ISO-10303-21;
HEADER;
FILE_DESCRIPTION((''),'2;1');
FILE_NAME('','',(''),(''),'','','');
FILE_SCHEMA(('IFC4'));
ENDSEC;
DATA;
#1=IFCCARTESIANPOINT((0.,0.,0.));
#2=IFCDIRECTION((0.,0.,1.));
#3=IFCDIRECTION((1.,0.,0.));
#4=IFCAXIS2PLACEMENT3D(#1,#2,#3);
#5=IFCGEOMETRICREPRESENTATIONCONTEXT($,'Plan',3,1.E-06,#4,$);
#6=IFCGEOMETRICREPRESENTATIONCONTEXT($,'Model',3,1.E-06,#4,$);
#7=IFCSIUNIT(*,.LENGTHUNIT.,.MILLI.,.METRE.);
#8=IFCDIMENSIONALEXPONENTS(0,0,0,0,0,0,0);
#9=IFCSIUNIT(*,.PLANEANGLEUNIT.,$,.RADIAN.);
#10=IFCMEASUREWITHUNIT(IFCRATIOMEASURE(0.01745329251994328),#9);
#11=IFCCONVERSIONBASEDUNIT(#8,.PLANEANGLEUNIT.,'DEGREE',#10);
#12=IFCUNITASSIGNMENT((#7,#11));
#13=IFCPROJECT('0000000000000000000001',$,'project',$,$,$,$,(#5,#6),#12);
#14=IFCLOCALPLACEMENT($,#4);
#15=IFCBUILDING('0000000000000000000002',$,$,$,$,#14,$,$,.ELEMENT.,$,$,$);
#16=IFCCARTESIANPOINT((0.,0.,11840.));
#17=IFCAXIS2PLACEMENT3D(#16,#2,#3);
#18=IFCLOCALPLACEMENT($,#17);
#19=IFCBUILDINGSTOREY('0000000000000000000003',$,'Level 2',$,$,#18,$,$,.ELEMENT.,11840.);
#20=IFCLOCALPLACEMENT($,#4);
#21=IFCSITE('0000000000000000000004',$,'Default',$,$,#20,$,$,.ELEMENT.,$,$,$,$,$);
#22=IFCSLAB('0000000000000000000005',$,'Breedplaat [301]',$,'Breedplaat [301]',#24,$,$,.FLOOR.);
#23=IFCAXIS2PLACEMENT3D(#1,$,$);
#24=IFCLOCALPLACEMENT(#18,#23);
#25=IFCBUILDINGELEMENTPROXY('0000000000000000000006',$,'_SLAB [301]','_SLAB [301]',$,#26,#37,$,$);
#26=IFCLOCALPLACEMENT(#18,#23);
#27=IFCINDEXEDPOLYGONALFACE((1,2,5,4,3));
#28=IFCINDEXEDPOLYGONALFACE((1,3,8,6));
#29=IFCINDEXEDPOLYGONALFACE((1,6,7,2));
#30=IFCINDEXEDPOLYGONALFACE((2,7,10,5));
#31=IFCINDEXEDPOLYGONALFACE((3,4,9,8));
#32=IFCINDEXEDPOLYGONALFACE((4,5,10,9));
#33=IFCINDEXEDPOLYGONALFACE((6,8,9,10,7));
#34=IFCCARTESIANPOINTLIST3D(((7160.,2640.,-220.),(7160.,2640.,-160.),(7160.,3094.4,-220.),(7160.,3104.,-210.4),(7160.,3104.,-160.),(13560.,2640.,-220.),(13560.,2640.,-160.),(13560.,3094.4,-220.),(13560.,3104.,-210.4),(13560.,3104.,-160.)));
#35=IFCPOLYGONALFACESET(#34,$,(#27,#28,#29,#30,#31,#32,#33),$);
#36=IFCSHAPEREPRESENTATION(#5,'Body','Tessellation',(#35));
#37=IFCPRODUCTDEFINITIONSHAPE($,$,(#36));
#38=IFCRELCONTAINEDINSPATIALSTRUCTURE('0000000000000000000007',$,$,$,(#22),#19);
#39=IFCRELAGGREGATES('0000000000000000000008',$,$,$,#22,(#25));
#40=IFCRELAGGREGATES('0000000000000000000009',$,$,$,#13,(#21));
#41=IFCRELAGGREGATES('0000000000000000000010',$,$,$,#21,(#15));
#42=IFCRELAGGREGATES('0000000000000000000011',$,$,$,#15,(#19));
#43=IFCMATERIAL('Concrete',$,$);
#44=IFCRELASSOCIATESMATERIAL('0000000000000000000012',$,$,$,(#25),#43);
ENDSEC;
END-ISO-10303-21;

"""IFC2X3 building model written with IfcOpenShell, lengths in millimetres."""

from ifc_helpers import new_model, entity, si_unit, converted_unit, frame, origin_with_axes, place, context, project, spatial, polyline, outline, extrude, material, element, aggregate, save


model = new_model("IFC2X3")

# Units and contexts
plan_context = context("Plan", 3, precision=1e-06, world=origin_with_axes())
model_context = context("Model", 3, precision=1e-06, world=origin_with_axes())
ifc_project = project(units=[si_unit("LENGTHUNIT", "METRE", prefix="MILLI"), converted_unit("PLANEANGLEUNIT", "DEGREE", entity("IfcRatioMeasure", 0.01745329251994328), si_unit("PLANEANGLEUNIT", "RADIAN"), dimensions=[0, 0, 0, 0, 0, 0, 0])], contexts=[plan_context, model_context])

# Site, building, storey
site_placement = place(None, origin_with_axes())
site = spatial("IfcSite", under=ifc_project, at=site_placement, Name="Default", CompositionType="ELEMENT")
building_placement = place(None, origin_with_axes())
building = spatial("IfcBuilding", under=site, at=building_placement, CompositionType="ELEMENT")
storey_placement = place(None, frame((0.0, 0.0, 11840.0), z_axis=(0.0, 0.0, 1.0), x_axis=(1.0, 0.0, 0.0)))
storey = spatial("IfcBuildingStorey", under=building, at=storey_placement, Name="Level 2", CompositionType="ELEMENT", Elevation=11840.0)

# Slab, building element proxy, opening
slab_1_placement = place(None, frame((7160.0, 2640.0, 11620.0), z_axis=(0.0, 0.0, 1.0), x_axis=(1.0, 0.0, 0.0)))
slab_1 = element("IfcSlab", 1, at=slab_1_placement, inside=storey, Name="Breedplaat [301]", ObjectType="Breedplaat [301]", PredefinedType="FLOOR")
ifc_material_1 = material(Name="Concrete")
proxy_1_placement = place(slab_1_placement, origin_with_axes())
proxy_1 = element("IfcBuildingElementProxy", 2, at=proxy_1_placement, material=ifc_material_1, Name="_SLAB [301]", Description="_SLAB [301]", context=plan_context, shape_type="SweptSolid", body=[
    extrude(outline(polyline([(6400.0, 464.0), (0.0, 464.0), (0.0, 0.0), (6400.0, 0.0), (6400.0, 464.0)])), origin_with_axes(), (0.0, 0.0, 1.0), 60.0),
])
opening_1_placement = place(None, frame((7160.0, 2640.0, 11620.0), z_axis=(0.0, 0.0, 1.0), x_axis=(1.0, 0.0, 0.0)))
element("IfcOpeningElement", 3, at=opening_1_placement, cuts=proxy_1, ObjectType="Opening", context=plan_context, shape_type="SweptSolid", body=[
    extrude(outline(polyline([(-0.1, -0.1), (-0.1, 10.0), (10.0, -0.1), (-0.1, -0.1)])), frame((6401.2, 464.2, -0.1), z_axis=(-1.0, 0.0, 0.0), x_axis=(0.0, -1.0, 0.0)), (0.0, 0.0, 1.0), 6402.2),
])
aggregate(slab_1, [proxy_1])

save(model, "model.ifc")
